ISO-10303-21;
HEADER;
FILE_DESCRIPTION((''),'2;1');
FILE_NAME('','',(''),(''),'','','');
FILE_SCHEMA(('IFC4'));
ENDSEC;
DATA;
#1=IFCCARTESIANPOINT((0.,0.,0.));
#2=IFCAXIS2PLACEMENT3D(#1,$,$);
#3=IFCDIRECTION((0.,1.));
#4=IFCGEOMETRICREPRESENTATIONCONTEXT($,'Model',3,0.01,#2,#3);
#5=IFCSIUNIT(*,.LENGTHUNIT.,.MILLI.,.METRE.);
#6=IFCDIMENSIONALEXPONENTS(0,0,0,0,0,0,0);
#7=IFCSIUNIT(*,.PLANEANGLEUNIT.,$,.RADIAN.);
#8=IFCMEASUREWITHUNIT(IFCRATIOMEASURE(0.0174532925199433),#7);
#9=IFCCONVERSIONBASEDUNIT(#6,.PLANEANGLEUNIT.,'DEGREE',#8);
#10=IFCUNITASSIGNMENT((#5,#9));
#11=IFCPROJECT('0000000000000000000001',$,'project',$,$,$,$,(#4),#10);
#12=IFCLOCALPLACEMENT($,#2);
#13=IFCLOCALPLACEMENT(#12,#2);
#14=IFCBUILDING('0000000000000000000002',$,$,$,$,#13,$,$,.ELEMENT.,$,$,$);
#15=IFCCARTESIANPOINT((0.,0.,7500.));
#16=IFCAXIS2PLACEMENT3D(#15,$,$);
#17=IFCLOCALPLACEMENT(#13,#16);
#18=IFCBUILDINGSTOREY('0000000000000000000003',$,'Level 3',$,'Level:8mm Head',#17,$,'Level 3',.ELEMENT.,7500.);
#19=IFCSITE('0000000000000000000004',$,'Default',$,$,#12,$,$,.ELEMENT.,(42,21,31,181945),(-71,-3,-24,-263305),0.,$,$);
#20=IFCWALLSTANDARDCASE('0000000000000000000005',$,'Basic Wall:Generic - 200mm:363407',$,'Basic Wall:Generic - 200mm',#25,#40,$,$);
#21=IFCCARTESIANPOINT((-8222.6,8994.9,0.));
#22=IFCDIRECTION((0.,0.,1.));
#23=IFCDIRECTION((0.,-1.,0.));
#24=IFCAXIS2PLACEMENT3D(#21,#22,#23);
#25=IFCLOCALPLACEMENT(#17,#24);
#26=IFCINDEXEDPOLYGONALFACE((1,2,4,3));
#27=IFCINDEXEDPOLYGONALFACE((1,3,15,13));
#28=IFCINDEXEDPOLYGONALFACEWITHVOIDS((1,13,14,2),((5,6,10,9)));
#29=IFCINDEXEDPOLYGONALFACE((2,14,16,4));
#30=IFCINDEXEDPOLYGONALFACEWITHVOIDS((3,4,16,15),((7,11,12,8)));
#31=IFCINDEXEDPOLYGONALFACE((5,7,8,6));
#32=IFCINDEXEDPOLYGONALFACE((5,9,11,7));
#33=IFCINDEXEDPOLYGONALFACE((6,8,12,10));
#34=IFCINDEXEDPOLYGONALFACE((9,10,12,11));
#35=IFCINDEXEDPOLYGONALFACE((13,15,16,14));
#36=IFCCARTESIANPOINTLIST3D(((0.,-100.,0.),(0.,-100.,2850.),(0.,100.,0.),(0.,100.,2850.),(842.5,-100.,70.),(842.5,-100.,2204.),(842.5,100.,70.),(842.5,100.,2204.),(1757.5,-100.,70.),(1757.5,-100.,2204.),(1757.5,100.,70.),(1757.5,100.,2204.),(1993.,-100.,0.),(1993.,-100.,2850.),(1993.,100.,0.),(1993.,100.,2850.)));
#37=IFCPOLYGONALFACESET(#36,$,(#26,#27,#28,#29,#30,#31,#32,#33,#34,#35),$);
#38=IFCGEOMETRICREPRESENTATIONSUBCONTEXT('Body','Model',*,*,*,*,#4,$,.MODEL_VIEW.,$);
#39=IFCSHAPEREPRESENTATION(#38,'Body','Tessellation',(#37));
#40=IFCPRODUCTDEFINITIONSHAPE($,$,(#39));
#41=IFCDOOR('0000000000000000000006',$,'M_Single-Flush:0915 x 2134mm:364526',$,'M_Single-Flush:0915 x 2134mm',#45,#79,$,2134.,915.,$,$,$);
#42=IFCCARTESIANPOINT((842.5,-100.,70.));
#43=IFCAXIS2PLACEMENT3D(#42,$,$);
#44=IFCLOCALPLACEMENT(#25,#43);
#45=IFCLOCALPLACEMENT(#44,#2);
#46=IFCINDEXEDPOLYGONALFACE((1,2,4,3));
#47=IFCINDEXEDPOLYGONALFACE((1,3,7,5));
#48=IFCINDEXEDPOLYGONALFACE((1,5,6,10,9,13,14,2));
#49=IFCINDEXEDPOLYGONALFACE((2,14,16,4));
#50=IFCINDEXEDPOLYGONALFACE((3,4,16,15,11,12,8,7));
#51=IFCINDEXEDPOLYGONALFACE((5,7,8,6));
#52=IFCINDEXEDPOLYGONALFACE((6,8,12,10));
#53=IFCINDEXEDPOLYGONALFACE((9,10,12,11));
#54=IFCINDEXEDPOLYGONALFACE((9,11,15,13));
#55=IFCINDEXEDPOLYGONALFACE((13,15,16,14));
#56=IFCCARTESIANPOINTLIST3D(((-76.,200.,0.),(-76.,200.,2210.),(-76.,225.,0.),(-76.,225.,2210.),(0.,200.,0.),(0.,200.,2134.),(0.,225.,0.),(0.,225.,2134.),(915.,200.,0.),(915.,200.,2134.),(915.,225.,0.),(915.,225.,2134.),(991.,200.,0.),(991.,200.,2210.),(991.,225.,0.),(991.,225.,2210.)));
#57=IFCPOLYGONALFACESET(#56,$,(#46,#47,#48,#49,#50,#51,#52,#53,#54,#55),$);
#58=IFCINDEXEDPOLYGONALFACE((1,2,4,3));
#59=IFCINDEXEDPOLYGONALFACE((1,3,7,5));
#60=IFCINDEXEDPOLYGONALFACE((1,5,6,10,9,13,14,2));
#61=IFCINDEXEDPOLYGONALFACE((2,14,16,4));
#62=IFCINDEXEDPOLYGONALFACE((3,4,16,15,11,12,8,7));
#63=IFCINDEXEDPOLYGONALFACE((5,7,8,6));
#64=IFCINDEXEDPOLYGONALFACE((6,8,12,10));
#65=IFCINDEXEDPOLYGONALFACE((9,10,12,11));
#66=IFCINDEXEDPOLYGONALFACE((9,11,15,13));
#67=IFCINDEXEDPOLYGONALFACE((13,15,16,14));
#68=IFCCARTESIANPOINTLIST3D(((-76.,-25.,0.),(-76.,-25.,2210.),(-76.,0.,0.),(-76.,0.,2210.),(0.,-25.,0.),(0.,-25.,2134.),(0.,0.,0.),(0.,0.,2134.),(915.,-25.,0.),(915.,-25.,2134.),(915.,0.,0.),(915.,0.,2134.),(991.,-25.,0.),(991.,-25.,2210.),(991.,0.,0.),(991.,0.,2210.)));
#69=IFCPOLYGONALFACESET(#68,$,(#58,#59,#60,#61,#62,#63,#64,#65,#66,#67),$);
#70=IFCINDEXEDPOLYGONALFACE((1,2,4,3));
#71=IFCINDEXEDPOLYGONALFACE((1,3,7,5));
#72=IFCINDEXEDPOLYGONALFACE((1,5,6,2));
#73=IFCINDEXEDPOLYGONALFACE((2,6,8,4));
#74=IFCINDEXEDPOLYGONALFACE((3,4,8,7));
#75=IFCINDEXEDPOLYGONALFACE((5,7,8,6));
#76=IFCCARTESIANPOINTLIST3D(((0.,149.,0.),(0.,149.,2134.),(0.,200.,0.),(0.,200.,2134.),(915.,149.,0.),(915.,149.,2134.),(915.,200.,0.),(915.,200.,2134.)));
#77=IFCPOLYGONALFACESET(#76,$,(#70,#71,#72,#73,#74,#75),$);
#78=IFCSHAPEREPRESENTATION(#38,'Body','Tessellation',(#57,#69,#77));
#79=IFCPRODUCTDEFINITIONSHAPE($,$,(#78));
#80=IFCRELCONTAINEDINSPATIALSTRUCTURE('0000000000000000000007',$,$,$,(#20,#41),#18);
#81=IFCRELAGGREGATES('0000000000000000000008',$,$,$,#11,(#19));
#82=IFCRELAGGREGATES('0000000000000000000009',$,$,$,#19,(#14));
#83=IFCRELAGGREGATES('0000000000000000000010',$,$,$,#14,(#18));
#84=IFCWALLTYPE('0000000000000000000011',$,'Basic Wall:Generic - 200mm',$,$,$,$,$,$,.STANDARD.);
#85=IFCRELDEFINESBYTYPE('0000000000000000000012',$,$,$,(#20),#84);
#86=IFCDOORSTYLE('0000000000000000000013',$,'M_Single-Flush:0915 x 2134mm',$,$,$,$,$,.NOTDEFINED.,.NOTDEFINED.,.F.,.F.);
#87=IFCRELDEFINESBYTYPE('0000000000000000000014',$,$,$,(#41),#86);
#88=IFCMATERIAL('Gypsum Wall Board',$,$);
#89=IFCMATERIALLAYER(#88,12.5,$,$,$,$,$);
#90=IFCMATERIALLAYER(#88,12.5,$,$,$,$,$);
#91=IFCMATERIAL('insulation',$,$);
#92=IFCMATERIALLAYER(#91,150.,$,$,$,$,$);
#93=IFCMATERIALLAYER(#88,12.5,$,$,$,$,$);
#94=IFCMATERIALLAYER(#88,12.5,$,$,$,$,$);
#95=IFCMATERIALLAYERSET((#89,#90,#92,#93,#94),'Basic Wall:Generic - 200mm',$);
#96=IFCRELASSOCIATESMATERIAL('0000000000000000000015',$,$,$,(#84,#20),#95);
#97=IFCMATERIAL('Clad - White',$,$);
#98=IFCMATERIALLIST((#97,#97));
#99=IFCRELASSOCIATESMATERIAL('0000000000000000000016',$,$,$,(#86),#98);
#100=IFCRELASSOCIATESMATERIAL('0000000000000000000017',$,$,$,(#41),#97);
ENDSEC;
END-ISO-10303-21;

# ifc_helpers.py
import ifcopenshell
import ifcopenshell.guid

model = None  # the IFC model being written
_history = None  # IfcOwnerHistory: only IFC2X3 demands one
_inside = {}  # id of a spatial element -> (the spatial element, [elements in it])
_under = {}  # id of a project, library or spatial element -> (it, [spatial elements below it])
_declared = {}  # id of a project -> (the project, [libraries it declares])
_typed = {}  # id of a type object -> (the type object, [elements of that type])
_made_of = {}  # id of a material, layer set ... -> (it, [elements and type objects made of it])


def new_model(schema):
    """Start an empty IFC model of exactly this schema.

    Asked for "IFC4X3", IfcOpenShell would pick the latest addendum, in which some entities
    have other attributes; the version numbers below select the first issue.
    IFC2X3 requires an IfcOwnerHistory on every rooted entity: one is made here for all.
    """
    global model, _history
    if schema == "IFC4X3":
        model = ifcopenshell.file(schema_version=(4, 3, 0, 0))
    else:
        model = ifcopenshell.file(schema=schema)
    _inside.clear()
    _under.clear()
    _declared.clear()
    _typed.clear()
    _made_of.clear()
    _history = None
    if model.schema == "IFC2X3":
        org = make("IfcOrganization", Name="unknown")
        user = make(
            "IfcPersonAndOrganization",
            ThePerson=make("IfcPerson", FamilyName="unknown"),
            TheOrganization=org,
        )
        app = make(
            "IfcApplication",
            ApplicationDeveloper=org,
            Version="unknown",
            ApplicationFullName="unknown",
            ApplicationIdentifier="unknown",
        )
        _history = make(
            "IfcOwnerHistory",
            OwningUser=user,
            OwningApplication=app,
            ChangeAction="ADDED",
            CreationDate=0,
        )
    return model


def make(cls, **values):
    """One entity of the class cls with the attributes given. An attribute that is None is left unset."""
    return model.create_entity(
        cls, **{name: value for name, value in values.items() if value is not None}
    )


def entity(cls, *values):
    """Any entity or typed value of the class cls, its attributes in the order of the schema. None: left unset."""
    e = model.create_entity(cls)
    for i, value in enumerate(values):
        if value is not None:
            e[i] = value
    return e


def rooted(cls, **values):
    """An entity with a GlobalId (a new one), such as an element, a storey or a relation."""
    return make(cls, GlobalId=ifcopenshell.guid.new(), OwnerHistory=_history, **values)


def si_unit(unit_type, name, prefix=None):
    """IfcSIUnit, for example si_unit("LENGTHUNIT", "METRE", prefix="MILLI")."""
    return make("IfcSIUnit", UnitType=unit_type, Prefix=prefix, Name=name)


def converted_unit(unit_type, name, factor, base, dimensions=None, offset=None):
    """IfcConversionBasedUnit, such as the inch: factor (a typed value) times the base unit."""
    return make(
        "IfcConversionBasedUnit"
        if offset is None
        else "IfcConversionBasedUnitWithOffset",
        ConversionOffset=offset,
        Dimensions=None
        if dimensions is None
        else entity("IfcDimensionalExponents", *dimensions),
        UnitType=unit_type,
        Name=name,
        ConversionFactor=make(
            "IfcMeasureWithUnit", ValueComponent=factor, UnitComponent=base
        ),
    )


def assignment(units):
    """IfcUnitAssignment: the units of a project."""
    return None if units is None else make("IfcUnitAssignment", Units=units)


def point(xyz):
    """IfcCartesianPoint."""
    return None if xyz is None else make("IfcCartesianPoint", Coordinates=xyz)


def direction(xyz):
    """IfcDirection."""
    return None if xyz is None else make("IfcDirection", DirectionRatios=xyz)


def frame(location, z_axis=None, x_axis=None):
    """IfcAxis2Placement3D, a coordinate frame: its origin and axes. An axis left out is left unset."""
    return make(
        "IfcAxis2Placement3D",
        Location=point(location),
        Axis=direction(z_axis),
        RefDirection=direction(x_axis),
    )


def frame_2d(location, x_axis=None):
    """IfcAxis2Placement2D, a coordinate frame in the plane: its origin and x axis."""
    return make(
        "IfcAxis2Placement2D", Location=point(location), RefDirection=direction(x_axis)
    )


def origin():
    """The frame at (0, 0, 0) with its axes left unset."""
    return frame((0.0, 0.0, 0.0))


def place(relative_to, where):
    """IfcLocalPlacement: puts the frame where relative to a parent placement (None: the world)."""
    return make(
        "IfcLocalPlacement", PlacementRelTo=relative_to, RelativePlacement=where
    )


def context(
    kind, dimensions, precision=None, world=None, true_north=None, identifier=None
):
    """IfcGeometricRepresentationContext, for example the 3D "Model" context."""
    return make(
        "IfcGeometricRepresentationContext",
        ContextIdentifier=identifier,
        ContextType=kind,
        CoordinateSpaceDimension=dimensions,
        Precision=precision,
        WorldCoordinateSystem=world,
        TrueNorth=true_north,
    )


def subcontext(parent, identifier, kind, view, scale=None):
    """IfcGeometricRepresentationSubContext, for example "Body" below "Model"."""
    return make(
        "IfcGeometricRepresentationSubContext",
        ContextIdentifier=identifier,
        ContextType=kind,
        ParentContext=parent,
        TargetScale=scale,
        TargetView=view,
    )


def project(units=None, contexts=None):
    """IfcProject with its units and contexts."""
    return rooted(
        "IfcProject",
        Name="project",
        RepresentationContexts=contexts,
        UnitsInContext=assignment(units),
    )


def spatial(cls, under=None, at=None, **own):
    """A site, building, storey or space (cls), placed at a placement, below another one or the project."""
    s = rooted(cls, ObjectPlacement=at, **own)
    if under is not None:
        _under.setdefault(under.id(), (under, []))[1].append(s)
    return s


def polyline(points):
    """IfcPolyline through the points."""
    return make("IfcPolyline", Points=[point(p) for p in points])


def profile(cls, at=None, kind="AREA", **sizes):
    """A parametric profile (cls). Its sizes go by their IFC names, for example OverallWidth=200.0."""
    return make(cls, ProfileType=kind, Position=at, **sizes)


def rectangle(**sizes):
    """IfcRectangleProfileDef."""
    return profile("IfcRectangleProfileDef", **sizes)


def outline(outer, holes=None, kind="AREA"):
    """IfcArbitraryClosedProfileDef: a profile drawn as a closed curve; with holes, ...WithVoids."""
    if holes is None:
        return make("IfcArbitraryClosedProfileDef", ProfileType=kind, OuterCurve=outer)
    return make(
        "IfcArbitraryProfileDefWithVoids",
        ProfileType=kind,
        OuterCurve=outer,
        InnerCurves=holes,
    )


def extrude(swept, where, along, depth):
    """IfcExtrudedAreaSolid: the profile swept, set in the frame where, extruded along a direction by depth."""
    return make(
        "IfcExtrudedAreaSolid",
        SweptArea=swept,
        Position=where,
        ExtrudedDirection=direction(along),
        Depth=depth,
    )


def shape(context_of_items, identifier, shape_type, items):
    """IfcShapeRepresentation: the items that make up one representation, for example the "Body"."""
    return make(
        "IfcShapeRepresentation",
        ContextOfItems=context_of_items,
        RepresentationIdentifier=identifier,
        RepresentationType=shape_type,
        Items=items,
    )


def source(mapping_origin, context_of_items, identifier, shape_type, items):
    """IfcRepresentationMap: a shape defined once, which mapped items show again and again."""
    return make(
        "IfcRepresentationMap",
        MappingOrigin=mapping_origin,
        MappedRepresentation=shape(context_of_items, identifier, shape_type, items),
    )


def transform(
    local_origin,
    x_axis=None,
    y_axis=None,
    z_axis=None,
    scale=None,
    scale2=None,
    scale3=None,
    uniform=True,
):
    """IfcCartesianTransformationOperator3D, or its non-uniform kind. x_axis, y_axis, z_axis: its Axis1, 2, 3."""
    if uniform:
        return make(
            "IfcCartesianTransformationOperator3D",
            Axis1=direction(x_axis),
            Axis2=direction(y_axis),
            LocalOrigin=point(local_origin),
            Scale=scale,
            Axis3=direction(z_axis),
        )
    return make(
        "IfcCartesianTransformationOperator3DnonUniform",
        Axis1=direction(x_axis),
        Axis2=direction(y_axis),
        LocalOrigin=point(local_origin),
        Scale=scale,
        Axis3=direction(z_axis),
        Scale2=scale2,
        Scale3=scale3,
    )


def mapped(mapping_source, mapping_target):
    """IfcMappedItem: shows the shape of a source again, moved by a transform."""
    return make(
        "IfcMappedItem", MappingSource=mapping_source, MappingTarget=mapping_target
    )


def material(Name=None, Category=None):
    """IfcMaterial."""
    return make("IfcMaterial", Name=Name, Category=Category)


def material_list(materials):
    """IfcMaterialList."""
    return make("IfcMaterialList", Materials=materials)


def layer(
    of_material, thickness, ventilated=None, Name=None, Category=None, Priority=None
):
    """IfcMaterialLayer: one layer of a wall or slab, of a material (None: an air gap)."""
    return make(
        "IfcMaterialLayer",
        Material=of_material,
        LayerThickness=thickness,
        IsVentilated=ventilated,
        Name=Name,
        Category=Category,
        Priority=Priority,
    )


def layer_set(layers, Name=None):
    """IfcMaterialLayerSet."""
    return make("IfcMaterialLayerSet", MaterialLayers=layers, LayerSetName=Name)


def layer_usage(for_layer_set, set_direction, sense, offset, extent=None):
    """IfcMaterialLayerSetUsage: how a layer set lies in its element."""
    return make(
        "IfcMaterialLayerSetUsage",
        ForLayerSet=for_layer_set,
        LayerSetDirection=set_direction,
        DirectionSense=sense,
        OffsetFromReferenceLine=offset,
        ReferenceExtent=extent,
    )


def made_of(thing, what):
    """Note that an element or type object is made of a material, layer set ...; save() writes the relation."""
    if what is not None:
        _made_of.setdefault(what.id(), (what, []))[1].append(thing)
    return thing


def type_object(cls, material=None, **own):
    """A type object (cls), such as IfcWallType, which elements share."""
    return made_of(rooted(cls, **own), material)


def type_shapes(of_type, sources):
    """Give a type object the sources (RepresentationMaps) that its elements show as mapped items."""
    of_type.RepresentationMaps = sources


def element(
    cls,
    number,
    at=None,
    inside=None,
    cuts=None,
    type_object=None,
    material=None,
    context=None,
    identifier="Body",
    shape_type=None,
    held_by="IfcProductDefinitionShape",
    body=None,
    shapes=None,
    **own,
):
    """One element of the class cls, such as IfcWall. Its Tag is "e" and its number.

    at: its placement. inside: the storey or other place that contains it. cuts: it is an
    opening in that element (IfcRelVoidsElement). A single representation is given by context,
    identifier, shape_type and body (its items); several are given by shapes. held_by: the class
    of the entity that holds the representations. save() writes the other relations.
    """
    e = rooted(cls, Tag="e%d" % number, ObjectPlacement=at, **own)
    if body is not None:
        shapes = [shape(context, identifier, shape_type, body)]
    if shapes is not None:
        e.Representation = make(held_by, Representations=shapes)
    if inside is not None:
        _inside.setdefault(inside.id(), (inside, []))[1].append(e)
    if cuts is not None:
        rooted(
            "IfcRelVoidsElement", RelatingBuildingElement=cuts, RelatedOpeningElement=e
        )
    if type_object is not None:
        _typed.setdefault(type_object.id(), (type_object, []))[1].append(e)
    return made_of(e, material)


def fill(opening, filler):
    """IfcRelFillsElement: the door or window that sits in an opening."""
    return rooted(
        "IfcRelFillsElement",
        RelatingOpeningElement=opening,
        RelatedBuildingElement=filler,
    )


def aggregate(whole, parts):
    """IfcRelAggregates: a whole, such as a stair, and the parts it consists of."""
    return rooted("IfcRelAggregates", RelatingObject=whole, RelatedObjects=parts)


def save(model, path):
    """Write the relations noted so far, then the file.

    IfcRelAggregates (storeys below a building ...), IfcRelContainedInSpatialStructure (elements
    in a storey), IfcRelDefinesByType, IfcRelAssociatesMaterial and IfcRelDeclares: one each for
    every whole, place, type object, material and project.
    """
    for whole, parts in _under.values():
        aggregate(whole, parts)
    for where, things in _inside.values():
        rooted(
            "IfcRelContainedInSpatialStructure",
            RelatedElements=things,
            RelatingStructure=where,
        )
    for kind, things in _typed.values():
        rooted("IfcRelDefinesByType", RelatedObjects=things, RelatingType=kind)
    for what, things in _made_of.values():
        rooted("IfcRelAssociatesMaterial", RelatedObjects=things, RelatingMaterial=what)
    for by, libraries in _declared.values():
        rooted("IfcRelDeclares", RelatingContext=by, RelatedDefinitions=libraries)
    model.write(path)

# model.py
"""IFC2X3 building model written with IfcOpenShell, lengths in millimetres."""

from ifc_helpers import new_model, entity, si_unit, converted_unit, direction, frame, frame_2d, origin, place, context, subcontext, project, spatial, polyline, rectangle, outline, extrude, source, transform, mapped, material, material_list, layer, layer_set, layer_usage, type_object, type_shapes, element, fill, save


model = new_model("IFC2X3")

# Units and contexts
model_context = context("Model", 3, precision=0.01, world=origin(), true_north=direction((0.0, 1.0)))
body_context = subcontext(model_context, "Body", "Model", "MODEL_VIEW")
ifc_project = project(units=[si_unit("LENGTHUNIT", "METRE", prefix="MILLI"), converted_unit("PLANEANGLEUNIT", "DEGREE", entity("IfcRatioMeasure", 0.0174532925199433), si_unit("PLANEANGLEUNIT", "RADIAN"), dimensions=[0, 0, 0, 0, 0, 0, 0])], contexts=[model_context])

# Site, building, storey
site_placement = place(None, frame((0.0, 0.0, 0.0)))
site = spatial("IfcSite", under=ifc_project, at=site_placement, Name="Default", CompositionType="ELEMENT", RefLatitude=(42, 21, 31, 181945), RefLongitude=(-71, -3, -24, -263305), RefElevation=0.0)
building_placement = place(site_placement, origin())
building = spatial("IfcBuilding", under=site, at=building_placement, CompositionType="ELEMENT")
storey_placement = place(building_placement, frame((0.0, 0.0, 7500.0)))
storey = spatial("IfcBuildingStorey", under=building, at=storey_placement, Name="Level 3", ObjectType="Level:8mm Head", LongName="Level 3", CompositionType="ELEMENT", Elevation=7500.0)

# Wall, opening, door
ifc_material_1 = material(Name="Gypsum Wall Board")
ifc_layer_1 = layer(ifc_material_1, 12.5)
ifc_layer_2 = layer(ifc_material_1, 12.5)
ifc_material_2 = material(Name="insulation")
ifc_layer_3 = layer(ifc_material_2, 150.0)
ifc_layer_4 = layer(ifc_material_1, 12.5)
ifc_layer_5 = layer(ifc_material_1, 12.5)
ifc_layer_set = layer_set([ifc_layer_1, ifc_layer_2, ifc_layer_3, ifc_layer_4, ifc_layer_5], Name="Basic Wall:Generic - 200mm")
ifc_layer_usage = layer_usage(ifc_layer_set, "AXIS2", "NEGATIVE", 100.0)
wall_type = type_object("IfcWallType", Name="Basic Wall:Generic - 200mm", PredefinedType="STANDARD", material=ifc_layer_set)
wall_placement = place(storey_placement, frame((-8222.6, 8994.9, 0.0), z_axis=(0.0, 0.0, 1.0), x_axis=(0.0, -1.0, 0.0)))
wall = element("IfcWallStandardCase", 1, at=wall_placement, inside=storey, type_object=wall_type, material=ifc_layer_usage, Name="Basic Wall:Generic - 200mm:363407", ObjectType="Basic Wall:Generic - 200mm", context=body_context, shape_type="SweptSolid", body=[
    extrude(rectangle(XDim=1993.0, YDim=200.0, at=frame_2d((996.5, 0.0), x_axis=(-1.0, 0.0))), origin(), (0.0, 0.0, 1.0), 2850.0),
])
opening_placement = place(wall_placement, frame((842.5, -100.0, 70.0)))
opening = element("IfcOpeningElement", 2, at=opening_placement, cuts=wall, ObjectType="Opening", context=body_context, shape_type="SweptSolid", body=[
    extrude(rectangle(XDim=915.0, YDim=2134.0, at=frame_2d((1067.0, 457.5), x_axis=(0.0, 1.0))), frame((0.0, 0.0, 0.0), z_axis=(0.0, 1.0, 0.0), x_axis=(0.0, 0.0, 1.0)), (0.0, 0.0, 1.0), 200.0),
])
ifc_material_3 = material(Name="Clad - White")
ifc_material_list = material_list([ifc_material_3, ifc_material_3])
door_style = type_object("IfcDoorStyle", Name="M_Single-Flush:0915 x 2134mm", ConstructionType="NOTDEFINED", OperationType="NOTDEFINED", ParameterTakesPrecedence=False, Sizeable=False, material=ifc_material_list)
shared_shape_1 = source(origin(), body_context, "Body", "SweptSolid", [
    extrude(outline(polyline([(-533.5, -1124.0), (533.5, -1124.0), (533.5, 1086.0), (457.5, 1086.0), (457.5, -1048.0), (-457.5, -1048.0), (-457.5, 1086.0), (-533.5, 1086.0), (-533.5, -1124.0)])), frame((457.5, 200.0, 1086.0), z_axis=(0.0, 1.0, 0.0), x_axis=(1.0, 0.0, 0.0)), (0.0, 0.0, 1.0), 25.0),
    extrude(outline(polyline([(-1124.0, -533.5), (1086.0, -533.5), (1086.0, -457.5), (-1048.0, -457.5), (-1048.0, 457.5), (1086.0, 457.5), (1086.0, 533.5), (-1124.0, 533.5), (-1124.0, -533.5)])), frame((457.5, -25.0, 1086.0), z_axis=(0.0, 1.0, 0.0), x_axis=(0.0, 0.0, -1.0)), (0.0, 0.0, 1.0), 25.0),
    extrude(rectangle(XDim=51.0, YDim=915.0, at=frame_2d((0.0, 0.0), x_axis=(1.0, 0.0))), frame((457.5, 174.5, 0.0), z_axis=(0.0, 0.0, 1.0), x_axis=(0.0, 1.0, 0.0)), (0.0, 0.0, 1.0), 2134.0),
])
type_shapes(door_style, [shared_shape_1])
door_placement = place(opening_placement, origin())
door = element("IfcDoor", 3, at=door_placement, inside=storey, type_object=door_style, material=ifc_material_3, Name="M_Single-Flush:0915 x 2134mm:364526", ObjectType="M_Single-Flush:0915 x 2134mm", OverallHeight=2134.0, OverallWidth=915.0, context=body_context, shape_type="MappedRepresentation", body=[
    mapped(shared_shape_1, transform((0.0, 0.0, 0.0), scale=1.0)),
])
fill(opening, door)

save(model, "model.ifc")
